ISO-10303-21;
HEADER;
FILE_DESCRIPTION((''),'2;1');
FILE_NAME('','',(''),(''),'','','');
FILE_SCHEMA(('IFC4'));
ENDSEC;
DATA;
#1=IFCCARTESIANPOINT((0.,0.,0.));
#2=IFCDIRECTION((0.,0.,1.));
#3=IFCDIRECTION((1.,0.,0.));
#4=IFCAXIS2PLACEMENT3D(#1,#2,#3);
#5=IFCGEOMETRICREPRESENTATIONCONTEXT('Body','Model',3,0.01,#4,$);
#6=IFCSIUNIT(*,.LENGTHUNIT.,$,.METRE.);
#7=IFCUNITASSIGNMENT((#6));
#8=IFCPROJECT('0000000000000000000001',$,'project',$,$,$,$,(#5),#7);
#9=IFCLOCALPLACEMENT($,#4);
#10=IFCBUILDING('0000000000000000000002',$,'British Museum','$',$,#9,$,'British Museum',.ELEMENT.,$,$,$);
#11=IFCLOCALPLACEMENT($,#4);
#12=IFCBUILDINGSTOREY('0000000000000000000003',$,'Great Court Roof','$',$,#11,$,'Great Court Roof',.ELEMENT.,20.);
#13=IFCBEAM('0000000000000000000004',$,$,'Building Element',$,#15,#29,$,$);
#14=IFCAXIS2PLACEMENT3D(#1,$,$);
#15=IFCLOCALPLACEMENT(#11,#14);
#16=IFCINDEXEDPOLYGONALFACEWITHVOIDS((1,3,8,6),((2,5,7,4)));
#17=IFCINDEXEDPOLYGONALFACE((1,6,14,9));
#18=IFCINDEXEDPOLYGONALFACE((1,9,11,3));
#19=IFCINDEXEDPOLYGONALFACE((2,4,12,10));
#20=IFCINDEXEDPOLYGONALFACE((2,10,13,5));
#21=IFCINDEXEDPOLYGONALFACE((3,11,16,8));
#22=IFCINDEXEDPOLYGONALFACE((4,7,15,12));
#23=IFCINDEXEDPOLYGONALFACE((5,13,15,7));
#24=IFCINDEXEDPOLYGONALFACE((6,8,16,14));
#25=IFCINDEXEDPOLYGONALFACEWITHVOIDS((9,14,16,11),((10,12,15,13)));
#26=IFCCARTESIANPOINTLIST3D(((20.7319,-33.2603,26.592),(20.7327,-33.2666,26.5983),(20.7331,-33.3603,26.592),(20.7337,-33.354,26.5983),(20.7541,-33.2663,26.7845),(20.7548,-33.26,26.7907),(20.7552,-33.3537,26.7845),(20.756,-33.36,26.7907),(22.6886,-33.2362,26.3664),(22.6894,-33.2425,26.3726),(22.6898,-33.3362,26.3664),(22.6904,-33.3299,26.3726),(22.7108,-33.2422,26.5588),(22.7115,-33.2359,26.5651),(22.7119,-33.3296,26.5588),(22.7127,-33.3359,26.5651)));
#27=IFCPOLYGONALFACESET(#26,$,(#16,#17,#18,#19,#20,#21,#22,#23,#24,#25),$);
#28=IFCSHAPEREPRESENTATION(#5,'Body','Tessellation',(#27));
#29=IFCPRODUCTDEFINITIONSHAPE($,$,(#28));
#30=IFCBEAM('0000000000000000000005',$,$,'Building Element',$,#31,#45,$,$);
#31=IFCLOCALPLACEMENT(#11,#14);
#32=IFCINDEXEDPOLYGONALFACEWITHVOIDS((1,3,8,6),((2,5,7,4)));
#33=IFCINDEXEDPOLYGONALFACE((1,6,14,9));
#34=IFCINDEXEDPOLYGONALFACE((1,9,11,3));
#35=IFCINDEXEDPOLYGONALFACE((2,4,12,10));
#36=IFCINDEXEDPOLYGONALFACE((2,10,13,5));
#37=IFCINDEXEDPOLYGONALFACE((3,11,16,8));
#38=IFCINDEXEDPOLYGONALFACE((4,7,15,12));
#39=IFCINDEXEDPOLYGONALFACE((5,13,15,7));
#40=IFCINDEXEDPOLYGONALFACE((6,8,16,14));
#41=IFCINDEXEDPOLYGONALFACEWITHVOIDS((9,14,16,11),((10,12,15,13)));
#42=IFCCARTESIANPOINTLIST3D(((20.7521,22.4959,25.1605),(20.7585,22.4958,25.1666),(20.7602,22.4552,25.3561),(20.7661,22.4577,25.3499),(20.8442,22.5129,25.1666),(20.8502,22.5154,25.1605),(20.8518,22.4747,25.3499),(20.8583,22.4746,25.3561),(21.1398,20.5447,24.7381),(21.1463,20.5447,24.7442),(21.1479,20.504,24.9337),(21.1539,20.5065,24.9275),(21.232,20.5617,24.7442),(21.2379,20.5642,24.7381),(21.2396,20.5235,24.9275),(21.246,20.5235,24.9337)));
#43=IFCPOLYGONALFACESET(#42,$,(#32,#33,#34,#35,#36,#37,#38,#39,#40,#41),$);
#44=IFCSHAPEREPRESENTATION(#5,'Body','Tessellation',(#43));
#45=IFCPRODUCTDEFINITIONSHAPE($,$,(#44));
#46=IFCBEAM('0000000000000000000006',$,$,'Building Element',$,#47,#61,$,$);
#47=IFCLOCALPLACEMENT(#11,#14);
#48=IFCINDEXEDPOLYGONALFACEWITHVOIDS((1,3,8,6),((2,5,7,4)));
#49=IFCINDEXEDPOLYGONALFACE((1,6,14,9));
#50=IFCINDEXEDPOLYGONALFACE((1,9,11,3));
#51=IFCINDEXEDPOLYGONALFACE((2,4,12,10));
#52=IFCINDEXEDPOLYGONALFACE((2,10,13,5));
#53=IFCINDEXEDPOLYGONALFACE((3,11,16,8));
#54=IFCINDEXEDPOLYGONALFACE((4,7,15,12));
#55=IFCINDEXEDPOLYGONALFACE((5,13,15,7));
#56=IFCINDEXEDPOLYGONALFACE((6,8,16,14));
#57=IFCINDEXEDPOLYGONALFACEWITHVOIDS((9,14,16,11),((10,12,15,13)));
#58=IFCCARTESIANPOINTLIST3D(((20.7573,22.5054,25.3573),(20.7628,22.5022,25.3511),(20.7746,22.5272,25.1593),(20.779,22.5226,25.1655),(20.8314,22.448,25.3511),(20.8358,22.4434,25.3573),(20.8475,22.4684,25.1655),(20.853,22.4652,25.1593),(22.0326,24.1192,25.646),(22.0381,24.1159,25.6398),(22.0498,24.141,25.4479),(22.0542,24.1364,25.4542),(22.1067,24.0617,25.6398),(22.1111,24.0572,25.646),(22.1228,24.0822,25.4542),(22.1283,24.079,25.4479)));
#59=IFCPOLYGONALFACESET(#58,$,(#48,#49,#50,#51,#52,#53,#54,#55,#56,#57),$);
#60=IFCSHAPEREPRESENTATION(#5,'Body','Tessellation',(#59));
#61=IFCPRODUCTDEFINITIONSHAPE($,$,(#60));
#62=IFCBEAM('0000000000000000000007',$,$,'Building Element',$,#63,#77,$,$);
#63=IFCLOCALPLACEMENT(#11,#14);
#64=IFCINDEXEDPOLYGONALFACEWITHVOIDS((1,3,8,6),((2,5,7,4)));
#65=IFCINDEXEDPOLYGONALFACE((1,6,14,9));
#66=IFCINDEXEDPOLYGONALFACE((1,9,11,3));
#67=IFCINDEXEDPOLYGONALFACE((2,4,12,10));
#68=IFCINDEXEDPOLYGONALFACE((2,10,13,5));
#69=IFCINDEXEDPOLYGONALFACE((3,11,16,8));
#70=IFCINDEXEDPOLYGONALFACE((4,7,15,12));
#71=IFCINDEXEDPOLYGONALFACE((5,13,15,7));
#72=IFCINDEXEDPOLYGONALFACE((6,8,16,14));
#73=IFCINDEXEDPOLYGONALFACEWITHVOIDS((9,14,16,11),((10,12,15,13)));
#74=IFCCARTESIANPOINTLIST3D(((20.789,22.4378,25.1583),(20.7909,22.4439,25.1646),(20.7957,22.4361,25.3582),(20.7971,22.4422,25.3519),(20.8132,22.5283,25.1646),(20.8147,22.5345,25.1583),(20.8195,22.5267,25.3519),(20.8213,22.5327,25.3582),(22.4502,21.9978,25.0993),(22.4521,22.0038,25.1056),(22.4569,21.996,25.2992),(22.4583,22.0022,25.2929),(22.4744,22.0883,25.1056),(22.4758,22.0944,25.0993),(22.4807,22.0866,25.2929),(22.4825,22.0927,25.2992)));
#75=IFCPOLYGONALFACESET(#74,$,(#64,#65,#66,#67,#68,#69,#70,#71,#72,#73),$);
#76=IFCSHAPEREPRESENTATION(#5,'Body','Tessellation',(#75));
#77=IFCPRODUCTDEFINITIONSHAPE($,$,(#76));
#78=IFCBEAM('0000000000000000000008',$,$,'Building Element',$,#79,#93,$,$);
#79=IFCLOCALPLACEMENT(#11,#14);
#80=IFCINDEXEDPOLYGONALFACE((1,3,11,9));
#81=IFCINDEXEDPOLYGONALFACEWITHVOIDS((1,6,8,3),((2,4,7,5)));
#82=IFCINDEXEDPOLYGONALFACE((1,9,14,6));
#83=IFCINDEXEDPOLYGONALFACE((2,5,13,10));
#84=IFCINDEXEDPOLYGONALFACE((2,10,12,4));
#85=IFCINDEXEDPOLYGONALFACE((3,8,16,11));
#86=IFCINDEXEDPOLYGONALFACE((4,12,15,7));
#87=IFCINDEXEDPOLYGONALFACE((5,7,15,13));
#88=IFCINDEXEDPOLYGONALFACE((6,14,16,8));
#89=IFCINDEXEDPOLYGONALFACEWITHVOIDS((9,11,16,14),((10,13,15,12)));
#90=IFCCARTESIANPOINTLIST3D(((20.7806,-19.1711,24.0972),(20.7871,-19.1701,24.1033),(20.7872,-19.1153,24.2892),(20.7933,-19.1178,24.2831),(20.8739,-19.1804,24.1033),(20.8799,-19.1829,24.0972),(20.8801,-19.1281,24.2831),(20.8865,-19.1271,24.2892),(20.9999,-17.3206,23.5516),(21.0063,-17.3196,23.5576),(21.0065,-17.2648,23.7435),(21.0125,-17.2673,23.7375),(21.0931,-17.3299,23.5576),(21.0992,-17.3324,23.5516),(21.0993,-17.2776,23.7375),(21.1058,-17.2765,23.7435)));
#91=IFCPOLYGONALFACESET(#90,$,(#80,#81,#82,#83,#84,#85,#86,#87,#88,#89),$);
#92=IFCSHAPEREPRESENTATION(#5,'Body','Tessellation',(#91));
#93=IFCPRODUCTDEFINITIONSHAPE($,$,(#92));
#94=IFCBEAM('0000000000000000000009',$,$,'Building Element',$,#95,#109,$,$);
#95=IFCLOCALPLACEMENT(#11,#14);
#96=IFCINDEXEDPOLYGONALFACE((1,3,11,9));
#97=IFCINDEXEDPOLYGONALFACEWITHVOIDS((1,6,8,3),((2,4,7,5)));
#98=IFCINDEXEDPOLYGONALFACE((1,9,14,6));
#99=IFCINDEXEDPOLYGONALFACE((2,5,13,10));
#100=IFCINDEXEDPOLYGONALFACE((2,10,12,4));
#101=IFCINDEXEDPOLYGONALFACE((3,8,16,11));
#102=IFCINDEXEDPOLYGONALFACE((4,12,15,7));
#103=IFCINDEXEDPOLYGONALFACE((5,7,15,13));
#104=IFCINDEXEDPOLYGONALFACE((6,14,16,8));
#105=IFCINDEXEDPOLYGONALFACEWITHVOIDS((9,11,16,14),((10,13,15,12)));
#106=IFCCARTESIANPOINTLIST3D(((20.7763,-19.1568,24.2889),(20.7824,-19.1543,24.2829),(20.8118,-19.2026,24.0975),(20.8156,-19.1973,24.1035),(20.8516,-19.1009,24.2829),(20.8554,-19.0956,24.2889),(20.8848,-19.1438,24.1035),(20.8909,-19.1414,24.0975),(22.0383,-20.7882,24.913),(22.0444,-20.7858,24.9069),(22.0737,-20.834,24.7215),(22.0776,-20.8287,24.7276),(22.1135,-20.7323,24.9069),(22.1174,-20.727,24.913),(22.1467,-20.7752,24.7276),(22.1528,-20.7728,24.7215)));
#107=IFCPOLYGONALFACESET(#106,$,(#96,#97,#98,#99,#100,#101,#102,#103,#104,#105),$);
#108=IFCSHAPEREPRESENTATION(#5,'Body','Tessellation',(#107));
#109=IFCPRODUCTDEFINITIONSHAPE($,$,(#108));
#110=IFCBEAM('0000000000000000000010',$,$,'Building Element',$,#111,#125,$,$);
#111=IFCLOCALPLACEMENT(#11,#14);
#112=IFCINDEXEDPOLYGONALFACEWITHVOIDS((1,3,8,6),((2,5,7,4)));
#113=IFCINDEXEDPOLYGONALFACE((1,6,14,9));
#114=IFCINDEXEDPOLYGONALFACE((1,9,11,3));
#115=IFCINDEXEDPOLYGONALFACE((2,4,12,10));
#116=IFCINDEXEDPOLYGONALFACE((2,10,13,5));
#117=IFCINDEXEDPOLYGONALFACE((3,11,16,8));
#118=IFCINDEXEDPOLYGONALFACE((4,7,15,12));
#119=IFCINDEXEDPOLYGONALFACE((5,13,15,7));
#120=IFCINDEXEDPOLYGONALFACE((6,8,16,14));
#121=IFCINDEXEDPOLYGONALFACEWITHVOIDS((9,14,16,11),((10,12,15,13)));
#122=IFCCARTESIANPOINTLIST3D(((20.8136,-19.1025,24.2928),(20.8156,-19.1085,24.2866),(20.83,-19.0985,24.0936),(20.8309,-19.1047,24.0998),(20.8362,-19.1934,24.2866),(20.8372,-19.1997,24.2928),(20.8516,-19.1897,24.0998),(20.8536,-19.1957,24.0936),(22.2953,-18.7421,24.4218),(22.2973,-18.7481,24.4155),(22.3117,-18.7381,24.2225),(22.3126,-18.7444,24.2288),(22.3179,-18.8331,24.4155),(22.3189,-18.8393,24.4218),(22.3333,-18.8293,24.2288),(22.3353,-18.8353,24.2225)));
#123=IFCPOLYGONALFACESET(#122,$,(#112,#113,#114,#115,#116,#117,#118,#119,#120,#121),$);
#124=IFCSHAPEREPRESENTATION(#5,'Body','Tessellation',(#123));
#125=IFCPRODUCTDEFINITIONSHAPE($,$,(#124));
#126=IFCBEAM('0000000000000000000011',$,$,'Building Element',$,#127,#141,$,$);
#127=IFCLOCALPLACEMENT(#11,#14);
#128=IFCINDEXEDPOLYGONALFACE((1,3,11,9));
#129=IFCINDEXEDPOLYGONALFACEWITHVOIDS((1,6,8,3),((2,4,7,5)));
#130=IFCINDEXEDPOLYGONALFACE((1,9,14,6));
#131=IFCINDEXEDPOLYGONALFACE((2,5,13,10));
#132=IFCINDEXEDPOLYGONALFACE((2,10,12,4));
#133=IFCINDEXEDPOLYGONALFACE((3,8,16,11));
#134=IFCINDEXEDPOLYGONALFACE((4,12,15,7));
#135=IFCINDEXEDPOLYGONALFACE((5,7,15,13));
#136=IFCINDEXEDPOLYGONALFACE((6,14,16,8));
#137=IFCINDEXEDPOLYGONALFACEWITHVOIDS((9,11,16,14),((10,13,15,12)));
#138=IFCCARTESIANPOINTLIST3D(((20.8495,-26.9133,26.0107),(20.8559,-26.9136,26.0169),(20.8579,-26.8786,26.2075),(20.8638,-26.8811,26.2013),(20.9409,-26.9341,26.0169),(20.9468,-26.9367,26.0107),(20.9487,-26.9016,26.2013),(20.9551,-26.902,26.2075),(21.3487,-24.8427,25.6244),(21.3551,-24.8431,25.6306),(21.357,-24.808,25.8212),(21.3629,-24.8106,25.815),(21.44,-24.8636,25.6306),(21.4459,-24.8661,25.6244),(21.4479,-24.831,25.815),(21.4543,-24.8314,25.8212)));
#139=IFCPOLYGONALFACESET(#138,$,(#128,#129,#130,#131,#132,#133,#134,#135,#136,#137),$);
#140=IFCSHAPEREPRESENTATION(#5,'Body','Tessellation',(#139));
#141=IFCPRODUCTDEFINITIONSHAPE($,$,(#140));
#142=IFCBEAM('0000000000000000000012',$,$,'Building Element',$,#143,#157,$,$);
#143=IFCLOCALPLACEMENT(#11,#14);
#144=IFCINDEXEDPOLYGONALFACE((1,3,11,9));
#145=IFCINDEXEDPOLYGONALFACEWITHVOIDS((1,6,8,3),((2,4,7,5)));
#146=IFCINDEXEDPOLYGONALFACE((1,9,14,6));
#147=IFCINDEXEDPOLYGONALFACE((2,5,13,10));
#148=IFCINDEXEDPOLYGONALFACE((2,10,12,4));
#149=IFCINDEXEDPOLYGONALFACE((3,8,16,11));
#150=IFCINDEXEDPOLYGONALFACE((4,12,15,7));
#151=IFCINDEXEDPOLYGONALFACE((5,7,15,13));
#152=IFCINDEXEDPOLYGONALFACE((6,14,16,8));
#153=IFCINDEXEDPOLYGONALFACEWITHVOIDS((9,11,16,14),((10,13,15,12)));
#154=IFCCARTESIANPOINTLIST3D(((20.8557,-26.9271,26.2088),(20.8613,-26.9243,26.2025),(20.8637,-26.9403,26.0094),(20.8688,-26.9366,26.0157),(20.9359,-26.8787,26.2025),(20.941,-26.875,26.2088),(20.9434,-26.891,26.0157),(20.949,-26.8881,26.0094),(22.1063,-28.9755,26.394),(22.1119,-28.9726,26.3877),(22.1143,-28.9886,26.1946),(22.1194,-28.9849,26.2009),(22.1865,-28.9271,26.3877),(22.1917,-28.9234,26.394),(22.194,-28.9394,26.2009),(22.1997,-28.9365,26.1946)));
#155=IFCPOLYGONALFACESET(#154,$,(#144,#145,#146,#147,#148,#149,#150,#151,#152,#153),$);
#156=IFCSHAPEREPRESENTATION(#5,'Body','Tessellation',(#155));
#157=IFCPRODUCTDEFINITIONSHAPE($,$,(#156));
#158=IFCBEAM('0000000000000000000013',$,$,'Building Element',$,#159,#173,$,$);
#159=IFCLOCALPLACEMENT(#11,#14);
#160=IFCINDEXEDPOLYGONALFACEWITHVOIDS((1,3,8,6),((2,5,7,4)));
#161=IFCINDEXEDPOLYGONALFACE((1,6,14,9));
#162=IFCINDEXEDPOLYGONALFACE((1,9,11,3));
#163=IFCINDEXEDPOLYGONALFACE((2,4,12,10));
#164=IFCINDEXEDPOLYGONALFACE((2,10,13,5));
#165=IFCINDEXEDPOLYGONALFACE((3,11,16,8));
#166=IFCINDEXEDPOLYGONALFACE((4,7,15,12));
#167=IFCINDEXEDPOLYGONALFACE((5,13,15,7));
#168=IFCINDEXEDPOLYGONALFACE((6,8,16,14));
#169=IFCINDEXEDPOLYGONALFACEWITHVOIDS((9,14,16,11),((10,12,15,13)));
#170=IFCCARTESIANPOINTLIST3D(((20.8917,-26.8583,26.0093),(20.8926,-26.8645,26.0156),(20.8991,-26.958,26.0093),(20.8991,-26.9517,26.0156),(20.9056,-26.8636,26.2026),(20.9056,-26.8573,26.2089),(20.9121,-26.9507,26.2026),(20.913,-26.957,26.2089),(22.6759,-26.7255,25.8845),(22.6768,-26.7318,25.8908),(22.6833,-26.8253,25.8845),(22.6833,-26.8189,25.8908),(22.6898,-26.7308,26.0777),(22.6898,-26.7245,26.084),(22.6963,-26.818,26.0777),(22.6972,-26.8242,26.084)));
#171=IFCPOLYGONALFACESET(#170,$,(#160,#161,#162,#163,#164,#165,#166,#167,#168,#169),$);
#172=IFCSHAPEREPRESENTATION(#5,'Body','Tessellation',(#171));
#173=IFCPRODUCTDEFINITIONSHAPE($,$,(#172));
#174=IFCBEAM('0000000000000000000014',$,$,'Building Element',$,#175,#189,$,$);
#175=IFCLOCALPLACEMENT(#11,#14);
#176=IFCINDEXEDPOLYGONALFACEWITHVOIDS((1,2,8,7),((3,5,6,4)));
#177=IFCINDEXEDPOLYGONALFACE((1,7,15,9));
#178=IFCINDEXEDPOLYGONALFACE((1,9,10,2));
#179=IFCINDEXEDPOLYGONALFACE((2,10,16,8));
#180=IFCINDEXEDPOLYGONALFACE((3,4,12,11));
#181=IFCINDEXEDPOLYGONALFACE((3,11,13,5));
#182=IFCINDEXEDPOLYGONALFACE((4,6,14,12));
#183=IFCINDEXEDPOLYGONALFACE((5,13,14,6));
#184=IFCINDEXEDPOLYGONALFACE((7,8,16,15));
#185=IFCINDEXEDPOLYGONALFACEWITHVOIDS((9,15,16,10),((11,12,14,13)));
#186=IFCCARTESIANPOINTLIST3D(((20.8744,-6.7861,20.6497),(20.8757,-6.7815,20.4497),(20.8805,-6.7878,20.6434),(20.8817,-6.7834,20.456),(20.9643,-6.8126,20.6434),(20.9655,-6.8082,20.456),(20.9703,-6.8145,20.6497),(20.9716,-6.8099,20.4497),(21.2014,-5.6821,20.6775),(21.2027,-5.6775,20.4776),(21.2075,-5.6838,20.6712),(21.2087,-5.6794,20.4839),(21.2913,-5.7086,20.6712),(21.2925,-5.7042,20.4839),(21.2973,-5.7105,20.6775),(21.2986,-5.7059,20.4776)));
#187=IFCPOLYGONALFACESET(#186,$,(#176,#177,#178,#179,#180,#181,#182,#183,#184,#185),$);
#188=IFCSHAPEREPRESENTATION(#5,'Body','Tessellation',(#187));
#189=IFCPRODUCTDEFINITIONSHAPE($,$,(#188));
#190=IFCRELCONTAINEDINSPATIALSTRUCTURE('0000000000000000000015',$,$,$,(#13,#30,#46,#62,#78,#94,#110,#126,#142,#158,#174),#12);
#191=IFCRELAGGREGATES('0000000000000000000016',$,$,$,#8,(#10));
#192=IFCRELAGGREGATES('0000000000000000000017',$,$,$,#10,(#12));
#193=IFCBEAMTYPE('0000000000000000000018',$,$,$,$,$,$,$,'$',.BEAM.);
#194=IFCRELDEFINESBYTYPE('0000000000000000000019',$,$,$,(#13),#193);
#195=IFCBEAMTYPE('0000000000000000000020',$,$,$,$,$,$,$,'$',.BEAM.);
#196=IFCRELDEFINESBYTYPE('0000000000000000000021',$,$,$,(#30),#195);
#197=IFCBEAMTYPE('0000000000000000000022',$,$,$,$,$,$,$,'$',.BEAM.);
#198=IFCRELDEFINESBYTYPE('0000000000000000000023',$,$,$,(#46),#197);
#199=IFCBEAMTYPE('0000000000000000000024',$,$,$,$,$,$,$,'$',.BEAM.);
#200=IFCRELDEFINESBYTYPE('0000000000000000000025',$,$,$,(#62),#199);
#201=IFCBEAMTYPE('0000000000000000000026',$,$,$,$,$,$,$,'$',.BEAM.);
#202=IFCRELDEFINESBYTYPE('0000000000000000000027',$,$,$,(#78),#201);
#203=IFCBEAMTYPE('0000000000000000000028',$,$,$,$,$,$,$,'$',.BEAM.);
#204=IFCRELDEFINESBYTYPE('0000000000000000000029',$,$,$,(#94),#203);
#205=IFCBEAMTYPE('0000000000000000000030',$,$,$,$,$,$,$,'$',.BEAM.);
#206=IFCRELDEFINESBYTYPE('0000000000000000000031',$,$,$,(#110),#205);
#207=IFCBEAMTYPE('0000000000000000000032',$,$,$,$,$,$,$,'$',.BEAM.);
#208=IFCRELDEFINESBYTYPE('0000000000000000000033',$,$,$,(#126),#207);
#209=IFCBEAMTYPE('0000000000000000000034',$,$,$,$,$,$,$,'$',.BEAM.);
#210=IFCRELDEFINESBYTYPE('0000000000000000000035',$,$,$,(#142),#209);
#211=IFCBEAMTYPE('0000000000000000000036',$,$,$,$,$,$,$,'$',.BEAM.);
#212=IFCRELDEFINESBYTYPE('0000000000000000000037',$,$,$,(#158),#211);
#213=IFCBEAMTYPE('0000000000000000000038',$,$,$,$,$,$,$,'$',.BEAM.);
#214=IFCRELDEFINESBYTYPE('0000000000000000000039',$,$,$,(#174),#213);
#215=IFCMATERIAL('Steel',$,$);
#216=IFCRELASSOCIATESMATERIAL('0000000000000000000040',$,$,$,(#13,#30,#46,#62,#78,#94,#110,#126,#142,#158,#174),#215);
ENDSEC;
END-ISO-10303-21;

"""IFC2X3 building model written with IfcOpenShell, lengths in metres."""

from ifc_helpers import new_model, si_unit, frame, origin_with_axes, origin_2d, place, context, project, spatial, hollow_rectangle, extrude, material, type_object, element, save


model = new_model("IFC2X3")

# Units and contexts
model_context = context("Model", 3, precision=0.01, world=origin_with_axes(), identifier="Body")
ifc_project = project(units=[si_unit("LENGTHUNIT", "METRE")], contexts=[model_context])

# Building, storey
building_placement = place(None, origin_with_axes())
building = spatial("IfcBuilding", under=ifc_project, at=building_placement, Name="British Museum", Description="$", LongName="British Museum", CompositionType="ELEMENT")
storey_placement = place(None, origin_with_axes())
storey = spatial("IfcBuildingStorey", under=building, at=storey_placement, Name="Great Court Roof", Description="$", LongName="Great Court Roof", CompositionType="ELEMENT", Elevation=20.0)

# Beams
ifc_material = material(Name="Steel")
beam_type_1 = type_object("IfcBeamType", ElementType="$", PredefinedType="BEAM")
beam_1_placement = place(None, origin_with_axes())
element("IfcBeam", 1, at=beam_1_placement, inside=storey, type_object=beam_type_1, material=ifc_material, Description="Building Element", context=model_context, shape_type="SweptSolid", body=[
    extrude(hollow_rectangle(XDim=0.1, YDim=0.2, WallThickness=0.0063, InnerFilletRadius=-0.0063, OuterFilletRadius=0.0, at=origin_2d()), frame((20.7439, -33.3101, 26.6914), z_axis=(0.993342, 0.012223, -0.114555), x_axis=(-0.012304, 0.999924, 0.0)), (0.0, 0.0, 1.0), 1.9698),
])
beam_type_2 = type_object("IfcBeamType", ElementType="$", PredefinedType="BEAM")
beam_2_placement = place(None, origin_with_axes())
element("IfcBeam", 2, at=beam_2_placement, inside=storey, type_object=beam_type_2, material=ifc_material, Description="Building Element", context=model_context, shape_type="SweptSolid", body=[
    extrude(hollow_rectangle(XDim=0.1, YDim=0.2, WallThickness=0.0063, InnerFilletRadius=-0.0063, OuterFilletRadius=0.0, at=origin_2d()), frame((20.8052, 22.4853, 25.2583), z_axis=(0.190667, -0.959429, -0.207705), x_axis=(0.98082, 0.194918, 0.0)), (0.0, 0.0, 1.0), 2.0337),
])
beam_type_3 = type_object("IfcBeamType", ElementType="$", PredefinedType="BEAM")
beam_3_placement = place(None, origin_with_axes())
element("IfcBeam", 3, at=beam_3_placement, inside=storey, type_object=beam_type_3, material=ifc_material, Description="Building Element", context=model_context, shape_type="SweptSolid", body=[
    extrude(hollow_rectangle(XDim=0.1, YDim=0.2, WallThickness=0.0063, InnerFilletRadius=-0.0063, OuterFilletRadius=0.0, at=origin_2d()), frame((20.8052, 22.4853, 25.2583), z_axis=(0.613999, 0.776974, 0.138985), x_axis=(-0.784589, 0.620017, 0.0)), (0.0, 0.0, 1.0), 2.077),
])
beam_type_4 = type_object("IfcBeamType", ElementType="$", PredefinedType="BEAM")
beam_4_placement = place(None, origin_with_axes())
element("IfcBeam", 4, at=beam_4_placement, inside=storey, type_object=beam_type_4, material=ifc_material, Description="Building Element", context=model_context, shape_type="SweptSolid", body=[
    extrude(hollow_rectangle(XDim=0.1, YDim=0.2, WallThickness=0.0063, InnerFilletRadius=-0.0063, OuterFilletRadius=0.0, at=origin_2d()), frame((20.8052, 22.4853, 25.2583), z_axis=(0.966089, -0.255915, -0.03434), x_axis=(0.256066, 0.966659, 0.0)), (0.0, 0.0, 1.0), 1.7195),
])
beam_type_5 = type_object("IfcBeamType", ElementType="$", PredefinedType="BEAM")
beam_5_placement = place(None, origin_with_axes())
element("IfcBeam", 5, at=beam_5_placement, inside=storey, type_object=beam_type_5, material=ifc_material, Description="Building Element", context=model_context, shape_type="SweptSolid", body=[
    extrude(hollow_rectangle(XDim=0.1, YDim=0.2, WallThickness=0.0063, InnerFilletRadius=-0.0063, OuterFilletRadius=0.0, at=origin_2d()), frame((20.8336, -19.1491, 24.1932), z_axis=(0.112908, 0.953042, -0.281005), x_axis=(-0.993055, 0.117649, 0.0)), (0.0, 0.0, 1.0), 1.9417),
])
beam_type_6 = type_object("IfcBeamType", ElementType="$", PredefinedType="BEAM")
beam_6_placement = place(None, origin_with_axes())
element("IfcBeam", 6, at=beam_6_placement, inside=storey, type_object=beam_type_6, material=ifc_material, Description="Building Element", context=model_context, shape_type="SweptSolid", body=[
    extrude(hollow_rectangle(XDim=0.1, YDim=0.2, WallThickness=0.0063, InnerFilletRadius=-0.0063, OuterFilletRadius=0.0, at=origin_2d()), frame((20.8336, -19.1491, 24.1932), z_axis=(0.585617, -0.757089, 0.289602), x_axis=(0.790985, 0.611836, 0.0)), (0.0, 0.0, 1.0), 2.1549),
])
beam_type_7 = type_object("IfcBeamType", ElementType="$", PredefinedType="BEAM")
beam_7_placement = place(None, origin_with_axes())
element("IfcBeam", 7, at=beam_7_placement, inside=storey, type_object=beam_type_7, material=ifc_material, Description="Building Element", context=model_context, shape_type="SweptSolid", body=[
    extrude(hollow_rectangle(XDim=0.1, YDim=0.2, WallThickness=0.0063, InnerFilletRadius=-0.0063, OuterFilletRadius=0.0, at=origin_2d()), frame((20.8336, -19.1491, 24.1932), z_axis=(0.96822, 0.235475, 0.084272), x_axis=(-0.236315, 0.971676, 0.0)), (0.0, 0.0, 1.0), 1.5303),
])
beam_type_8 = type_object("IfcBeamType", ElementType="$", PredefinedType="BEAM")
beam_8_placement = place(None, origin_with_axes())
element("IfcBeam", 8, at=beam_8_placement, inside=storey, type_object=beam_type_8, material=ifc_material, Description="Building Element", context=model_context, shape_type="SweptSolid", body=[
    extrude(hollow_rectangle(XDim=0.1, YDim=0.2, WallThickness=0.0063, InnerFilletRadius=-0.0063, OuterFilletRadius=0.0, at=origin_2d()), frame((20.9023, -26.9076, 26.1091), z_axis=(0.230588, 0.956551, -0.178437), x_axis=(-0.972153, 0.234349, 0.0)), (0.0, 0.0, 1.0), 2.1646),
])
beam_type_9 = type_object("IfcBeamType", ElementType="$", PredefinedType="BEAM")
beam_9_placement = place(None, origin_with_axes())
element("IfcBeam", 9, at=beam_9_placement, inside=storey, type_object=beam_type_9, material=ifc_material, Description="Building Element", context=model_context, shape_type="SweptSolid", body=[
    extrude(hollow_rectangle(XDim=0.1, YDim=0.2, WallThickness=0.0063, InnerFilletRadius=-0.0063, OuterFilletRadius=0.0, at=origin_2d()), frame((20.9023, -26.9076, 26.1091), z_axis=(0.519566, -0.850959, 0.076943), x_axis=(0.853489, 0.521111, 0.0)), (0.0, 0.0, 1.0), 2.4071),
])
beam_type_10 = type_object("IfcBeamType", ElementType="$", PredefinedType="BEAM")
beam_10_placement = place(None, origin_with_axes())
element("IfcBeam", 10, at=beam_10_placement, inside=storey, type_object=beam_type_10, material=ifc_material, Description="Building Element", context=model_context, shape_type="SweptSolid", body=[
    extrude(hollow_rectangle(XDim=0.1, YDim=0.2, WallThickness=0.0063, InnerFilletRadius=-0.0063, OuterFilletRadius=0.0, at=origin_2d()), frame((20.9023, -26.9076, 26.1091), z_axis=(0.994824, 0.07402, -0.069616), x_axis=(-0.0742, 0.997243, 0.0)), (0.0, 0.0, 1.0), 1.7935),
])
beam_type_11 = type_object("IfcBeamType", ElementType="$", PredefinedType="BEAM")
beam_11_placement = place(None, origin_with_axes())
element("IfcBeam", 11, at=beam_11_placement, inside=storey, type_object=beam_type_11, material=ifc_material, Description="Building Element", context=model_context, shape_type="SweptSolid", body=[
    extrude(hollow_rectangle(XDim=0.1, YDim=0.2, WallThickness=0.0063, InnerFilletRadius=-0.0063, OuterFilletRadius=0.0, at=origin_2d()), frame((20.923, -6.798, 20.5497), z_axis=(0.283917, 0.958544, 0.024167), x_axis=(-0.958824, 0.284, 0.0)), (0.0, 0.0, 1.0), 1.1517),
])

save(model, "model.ifc")
